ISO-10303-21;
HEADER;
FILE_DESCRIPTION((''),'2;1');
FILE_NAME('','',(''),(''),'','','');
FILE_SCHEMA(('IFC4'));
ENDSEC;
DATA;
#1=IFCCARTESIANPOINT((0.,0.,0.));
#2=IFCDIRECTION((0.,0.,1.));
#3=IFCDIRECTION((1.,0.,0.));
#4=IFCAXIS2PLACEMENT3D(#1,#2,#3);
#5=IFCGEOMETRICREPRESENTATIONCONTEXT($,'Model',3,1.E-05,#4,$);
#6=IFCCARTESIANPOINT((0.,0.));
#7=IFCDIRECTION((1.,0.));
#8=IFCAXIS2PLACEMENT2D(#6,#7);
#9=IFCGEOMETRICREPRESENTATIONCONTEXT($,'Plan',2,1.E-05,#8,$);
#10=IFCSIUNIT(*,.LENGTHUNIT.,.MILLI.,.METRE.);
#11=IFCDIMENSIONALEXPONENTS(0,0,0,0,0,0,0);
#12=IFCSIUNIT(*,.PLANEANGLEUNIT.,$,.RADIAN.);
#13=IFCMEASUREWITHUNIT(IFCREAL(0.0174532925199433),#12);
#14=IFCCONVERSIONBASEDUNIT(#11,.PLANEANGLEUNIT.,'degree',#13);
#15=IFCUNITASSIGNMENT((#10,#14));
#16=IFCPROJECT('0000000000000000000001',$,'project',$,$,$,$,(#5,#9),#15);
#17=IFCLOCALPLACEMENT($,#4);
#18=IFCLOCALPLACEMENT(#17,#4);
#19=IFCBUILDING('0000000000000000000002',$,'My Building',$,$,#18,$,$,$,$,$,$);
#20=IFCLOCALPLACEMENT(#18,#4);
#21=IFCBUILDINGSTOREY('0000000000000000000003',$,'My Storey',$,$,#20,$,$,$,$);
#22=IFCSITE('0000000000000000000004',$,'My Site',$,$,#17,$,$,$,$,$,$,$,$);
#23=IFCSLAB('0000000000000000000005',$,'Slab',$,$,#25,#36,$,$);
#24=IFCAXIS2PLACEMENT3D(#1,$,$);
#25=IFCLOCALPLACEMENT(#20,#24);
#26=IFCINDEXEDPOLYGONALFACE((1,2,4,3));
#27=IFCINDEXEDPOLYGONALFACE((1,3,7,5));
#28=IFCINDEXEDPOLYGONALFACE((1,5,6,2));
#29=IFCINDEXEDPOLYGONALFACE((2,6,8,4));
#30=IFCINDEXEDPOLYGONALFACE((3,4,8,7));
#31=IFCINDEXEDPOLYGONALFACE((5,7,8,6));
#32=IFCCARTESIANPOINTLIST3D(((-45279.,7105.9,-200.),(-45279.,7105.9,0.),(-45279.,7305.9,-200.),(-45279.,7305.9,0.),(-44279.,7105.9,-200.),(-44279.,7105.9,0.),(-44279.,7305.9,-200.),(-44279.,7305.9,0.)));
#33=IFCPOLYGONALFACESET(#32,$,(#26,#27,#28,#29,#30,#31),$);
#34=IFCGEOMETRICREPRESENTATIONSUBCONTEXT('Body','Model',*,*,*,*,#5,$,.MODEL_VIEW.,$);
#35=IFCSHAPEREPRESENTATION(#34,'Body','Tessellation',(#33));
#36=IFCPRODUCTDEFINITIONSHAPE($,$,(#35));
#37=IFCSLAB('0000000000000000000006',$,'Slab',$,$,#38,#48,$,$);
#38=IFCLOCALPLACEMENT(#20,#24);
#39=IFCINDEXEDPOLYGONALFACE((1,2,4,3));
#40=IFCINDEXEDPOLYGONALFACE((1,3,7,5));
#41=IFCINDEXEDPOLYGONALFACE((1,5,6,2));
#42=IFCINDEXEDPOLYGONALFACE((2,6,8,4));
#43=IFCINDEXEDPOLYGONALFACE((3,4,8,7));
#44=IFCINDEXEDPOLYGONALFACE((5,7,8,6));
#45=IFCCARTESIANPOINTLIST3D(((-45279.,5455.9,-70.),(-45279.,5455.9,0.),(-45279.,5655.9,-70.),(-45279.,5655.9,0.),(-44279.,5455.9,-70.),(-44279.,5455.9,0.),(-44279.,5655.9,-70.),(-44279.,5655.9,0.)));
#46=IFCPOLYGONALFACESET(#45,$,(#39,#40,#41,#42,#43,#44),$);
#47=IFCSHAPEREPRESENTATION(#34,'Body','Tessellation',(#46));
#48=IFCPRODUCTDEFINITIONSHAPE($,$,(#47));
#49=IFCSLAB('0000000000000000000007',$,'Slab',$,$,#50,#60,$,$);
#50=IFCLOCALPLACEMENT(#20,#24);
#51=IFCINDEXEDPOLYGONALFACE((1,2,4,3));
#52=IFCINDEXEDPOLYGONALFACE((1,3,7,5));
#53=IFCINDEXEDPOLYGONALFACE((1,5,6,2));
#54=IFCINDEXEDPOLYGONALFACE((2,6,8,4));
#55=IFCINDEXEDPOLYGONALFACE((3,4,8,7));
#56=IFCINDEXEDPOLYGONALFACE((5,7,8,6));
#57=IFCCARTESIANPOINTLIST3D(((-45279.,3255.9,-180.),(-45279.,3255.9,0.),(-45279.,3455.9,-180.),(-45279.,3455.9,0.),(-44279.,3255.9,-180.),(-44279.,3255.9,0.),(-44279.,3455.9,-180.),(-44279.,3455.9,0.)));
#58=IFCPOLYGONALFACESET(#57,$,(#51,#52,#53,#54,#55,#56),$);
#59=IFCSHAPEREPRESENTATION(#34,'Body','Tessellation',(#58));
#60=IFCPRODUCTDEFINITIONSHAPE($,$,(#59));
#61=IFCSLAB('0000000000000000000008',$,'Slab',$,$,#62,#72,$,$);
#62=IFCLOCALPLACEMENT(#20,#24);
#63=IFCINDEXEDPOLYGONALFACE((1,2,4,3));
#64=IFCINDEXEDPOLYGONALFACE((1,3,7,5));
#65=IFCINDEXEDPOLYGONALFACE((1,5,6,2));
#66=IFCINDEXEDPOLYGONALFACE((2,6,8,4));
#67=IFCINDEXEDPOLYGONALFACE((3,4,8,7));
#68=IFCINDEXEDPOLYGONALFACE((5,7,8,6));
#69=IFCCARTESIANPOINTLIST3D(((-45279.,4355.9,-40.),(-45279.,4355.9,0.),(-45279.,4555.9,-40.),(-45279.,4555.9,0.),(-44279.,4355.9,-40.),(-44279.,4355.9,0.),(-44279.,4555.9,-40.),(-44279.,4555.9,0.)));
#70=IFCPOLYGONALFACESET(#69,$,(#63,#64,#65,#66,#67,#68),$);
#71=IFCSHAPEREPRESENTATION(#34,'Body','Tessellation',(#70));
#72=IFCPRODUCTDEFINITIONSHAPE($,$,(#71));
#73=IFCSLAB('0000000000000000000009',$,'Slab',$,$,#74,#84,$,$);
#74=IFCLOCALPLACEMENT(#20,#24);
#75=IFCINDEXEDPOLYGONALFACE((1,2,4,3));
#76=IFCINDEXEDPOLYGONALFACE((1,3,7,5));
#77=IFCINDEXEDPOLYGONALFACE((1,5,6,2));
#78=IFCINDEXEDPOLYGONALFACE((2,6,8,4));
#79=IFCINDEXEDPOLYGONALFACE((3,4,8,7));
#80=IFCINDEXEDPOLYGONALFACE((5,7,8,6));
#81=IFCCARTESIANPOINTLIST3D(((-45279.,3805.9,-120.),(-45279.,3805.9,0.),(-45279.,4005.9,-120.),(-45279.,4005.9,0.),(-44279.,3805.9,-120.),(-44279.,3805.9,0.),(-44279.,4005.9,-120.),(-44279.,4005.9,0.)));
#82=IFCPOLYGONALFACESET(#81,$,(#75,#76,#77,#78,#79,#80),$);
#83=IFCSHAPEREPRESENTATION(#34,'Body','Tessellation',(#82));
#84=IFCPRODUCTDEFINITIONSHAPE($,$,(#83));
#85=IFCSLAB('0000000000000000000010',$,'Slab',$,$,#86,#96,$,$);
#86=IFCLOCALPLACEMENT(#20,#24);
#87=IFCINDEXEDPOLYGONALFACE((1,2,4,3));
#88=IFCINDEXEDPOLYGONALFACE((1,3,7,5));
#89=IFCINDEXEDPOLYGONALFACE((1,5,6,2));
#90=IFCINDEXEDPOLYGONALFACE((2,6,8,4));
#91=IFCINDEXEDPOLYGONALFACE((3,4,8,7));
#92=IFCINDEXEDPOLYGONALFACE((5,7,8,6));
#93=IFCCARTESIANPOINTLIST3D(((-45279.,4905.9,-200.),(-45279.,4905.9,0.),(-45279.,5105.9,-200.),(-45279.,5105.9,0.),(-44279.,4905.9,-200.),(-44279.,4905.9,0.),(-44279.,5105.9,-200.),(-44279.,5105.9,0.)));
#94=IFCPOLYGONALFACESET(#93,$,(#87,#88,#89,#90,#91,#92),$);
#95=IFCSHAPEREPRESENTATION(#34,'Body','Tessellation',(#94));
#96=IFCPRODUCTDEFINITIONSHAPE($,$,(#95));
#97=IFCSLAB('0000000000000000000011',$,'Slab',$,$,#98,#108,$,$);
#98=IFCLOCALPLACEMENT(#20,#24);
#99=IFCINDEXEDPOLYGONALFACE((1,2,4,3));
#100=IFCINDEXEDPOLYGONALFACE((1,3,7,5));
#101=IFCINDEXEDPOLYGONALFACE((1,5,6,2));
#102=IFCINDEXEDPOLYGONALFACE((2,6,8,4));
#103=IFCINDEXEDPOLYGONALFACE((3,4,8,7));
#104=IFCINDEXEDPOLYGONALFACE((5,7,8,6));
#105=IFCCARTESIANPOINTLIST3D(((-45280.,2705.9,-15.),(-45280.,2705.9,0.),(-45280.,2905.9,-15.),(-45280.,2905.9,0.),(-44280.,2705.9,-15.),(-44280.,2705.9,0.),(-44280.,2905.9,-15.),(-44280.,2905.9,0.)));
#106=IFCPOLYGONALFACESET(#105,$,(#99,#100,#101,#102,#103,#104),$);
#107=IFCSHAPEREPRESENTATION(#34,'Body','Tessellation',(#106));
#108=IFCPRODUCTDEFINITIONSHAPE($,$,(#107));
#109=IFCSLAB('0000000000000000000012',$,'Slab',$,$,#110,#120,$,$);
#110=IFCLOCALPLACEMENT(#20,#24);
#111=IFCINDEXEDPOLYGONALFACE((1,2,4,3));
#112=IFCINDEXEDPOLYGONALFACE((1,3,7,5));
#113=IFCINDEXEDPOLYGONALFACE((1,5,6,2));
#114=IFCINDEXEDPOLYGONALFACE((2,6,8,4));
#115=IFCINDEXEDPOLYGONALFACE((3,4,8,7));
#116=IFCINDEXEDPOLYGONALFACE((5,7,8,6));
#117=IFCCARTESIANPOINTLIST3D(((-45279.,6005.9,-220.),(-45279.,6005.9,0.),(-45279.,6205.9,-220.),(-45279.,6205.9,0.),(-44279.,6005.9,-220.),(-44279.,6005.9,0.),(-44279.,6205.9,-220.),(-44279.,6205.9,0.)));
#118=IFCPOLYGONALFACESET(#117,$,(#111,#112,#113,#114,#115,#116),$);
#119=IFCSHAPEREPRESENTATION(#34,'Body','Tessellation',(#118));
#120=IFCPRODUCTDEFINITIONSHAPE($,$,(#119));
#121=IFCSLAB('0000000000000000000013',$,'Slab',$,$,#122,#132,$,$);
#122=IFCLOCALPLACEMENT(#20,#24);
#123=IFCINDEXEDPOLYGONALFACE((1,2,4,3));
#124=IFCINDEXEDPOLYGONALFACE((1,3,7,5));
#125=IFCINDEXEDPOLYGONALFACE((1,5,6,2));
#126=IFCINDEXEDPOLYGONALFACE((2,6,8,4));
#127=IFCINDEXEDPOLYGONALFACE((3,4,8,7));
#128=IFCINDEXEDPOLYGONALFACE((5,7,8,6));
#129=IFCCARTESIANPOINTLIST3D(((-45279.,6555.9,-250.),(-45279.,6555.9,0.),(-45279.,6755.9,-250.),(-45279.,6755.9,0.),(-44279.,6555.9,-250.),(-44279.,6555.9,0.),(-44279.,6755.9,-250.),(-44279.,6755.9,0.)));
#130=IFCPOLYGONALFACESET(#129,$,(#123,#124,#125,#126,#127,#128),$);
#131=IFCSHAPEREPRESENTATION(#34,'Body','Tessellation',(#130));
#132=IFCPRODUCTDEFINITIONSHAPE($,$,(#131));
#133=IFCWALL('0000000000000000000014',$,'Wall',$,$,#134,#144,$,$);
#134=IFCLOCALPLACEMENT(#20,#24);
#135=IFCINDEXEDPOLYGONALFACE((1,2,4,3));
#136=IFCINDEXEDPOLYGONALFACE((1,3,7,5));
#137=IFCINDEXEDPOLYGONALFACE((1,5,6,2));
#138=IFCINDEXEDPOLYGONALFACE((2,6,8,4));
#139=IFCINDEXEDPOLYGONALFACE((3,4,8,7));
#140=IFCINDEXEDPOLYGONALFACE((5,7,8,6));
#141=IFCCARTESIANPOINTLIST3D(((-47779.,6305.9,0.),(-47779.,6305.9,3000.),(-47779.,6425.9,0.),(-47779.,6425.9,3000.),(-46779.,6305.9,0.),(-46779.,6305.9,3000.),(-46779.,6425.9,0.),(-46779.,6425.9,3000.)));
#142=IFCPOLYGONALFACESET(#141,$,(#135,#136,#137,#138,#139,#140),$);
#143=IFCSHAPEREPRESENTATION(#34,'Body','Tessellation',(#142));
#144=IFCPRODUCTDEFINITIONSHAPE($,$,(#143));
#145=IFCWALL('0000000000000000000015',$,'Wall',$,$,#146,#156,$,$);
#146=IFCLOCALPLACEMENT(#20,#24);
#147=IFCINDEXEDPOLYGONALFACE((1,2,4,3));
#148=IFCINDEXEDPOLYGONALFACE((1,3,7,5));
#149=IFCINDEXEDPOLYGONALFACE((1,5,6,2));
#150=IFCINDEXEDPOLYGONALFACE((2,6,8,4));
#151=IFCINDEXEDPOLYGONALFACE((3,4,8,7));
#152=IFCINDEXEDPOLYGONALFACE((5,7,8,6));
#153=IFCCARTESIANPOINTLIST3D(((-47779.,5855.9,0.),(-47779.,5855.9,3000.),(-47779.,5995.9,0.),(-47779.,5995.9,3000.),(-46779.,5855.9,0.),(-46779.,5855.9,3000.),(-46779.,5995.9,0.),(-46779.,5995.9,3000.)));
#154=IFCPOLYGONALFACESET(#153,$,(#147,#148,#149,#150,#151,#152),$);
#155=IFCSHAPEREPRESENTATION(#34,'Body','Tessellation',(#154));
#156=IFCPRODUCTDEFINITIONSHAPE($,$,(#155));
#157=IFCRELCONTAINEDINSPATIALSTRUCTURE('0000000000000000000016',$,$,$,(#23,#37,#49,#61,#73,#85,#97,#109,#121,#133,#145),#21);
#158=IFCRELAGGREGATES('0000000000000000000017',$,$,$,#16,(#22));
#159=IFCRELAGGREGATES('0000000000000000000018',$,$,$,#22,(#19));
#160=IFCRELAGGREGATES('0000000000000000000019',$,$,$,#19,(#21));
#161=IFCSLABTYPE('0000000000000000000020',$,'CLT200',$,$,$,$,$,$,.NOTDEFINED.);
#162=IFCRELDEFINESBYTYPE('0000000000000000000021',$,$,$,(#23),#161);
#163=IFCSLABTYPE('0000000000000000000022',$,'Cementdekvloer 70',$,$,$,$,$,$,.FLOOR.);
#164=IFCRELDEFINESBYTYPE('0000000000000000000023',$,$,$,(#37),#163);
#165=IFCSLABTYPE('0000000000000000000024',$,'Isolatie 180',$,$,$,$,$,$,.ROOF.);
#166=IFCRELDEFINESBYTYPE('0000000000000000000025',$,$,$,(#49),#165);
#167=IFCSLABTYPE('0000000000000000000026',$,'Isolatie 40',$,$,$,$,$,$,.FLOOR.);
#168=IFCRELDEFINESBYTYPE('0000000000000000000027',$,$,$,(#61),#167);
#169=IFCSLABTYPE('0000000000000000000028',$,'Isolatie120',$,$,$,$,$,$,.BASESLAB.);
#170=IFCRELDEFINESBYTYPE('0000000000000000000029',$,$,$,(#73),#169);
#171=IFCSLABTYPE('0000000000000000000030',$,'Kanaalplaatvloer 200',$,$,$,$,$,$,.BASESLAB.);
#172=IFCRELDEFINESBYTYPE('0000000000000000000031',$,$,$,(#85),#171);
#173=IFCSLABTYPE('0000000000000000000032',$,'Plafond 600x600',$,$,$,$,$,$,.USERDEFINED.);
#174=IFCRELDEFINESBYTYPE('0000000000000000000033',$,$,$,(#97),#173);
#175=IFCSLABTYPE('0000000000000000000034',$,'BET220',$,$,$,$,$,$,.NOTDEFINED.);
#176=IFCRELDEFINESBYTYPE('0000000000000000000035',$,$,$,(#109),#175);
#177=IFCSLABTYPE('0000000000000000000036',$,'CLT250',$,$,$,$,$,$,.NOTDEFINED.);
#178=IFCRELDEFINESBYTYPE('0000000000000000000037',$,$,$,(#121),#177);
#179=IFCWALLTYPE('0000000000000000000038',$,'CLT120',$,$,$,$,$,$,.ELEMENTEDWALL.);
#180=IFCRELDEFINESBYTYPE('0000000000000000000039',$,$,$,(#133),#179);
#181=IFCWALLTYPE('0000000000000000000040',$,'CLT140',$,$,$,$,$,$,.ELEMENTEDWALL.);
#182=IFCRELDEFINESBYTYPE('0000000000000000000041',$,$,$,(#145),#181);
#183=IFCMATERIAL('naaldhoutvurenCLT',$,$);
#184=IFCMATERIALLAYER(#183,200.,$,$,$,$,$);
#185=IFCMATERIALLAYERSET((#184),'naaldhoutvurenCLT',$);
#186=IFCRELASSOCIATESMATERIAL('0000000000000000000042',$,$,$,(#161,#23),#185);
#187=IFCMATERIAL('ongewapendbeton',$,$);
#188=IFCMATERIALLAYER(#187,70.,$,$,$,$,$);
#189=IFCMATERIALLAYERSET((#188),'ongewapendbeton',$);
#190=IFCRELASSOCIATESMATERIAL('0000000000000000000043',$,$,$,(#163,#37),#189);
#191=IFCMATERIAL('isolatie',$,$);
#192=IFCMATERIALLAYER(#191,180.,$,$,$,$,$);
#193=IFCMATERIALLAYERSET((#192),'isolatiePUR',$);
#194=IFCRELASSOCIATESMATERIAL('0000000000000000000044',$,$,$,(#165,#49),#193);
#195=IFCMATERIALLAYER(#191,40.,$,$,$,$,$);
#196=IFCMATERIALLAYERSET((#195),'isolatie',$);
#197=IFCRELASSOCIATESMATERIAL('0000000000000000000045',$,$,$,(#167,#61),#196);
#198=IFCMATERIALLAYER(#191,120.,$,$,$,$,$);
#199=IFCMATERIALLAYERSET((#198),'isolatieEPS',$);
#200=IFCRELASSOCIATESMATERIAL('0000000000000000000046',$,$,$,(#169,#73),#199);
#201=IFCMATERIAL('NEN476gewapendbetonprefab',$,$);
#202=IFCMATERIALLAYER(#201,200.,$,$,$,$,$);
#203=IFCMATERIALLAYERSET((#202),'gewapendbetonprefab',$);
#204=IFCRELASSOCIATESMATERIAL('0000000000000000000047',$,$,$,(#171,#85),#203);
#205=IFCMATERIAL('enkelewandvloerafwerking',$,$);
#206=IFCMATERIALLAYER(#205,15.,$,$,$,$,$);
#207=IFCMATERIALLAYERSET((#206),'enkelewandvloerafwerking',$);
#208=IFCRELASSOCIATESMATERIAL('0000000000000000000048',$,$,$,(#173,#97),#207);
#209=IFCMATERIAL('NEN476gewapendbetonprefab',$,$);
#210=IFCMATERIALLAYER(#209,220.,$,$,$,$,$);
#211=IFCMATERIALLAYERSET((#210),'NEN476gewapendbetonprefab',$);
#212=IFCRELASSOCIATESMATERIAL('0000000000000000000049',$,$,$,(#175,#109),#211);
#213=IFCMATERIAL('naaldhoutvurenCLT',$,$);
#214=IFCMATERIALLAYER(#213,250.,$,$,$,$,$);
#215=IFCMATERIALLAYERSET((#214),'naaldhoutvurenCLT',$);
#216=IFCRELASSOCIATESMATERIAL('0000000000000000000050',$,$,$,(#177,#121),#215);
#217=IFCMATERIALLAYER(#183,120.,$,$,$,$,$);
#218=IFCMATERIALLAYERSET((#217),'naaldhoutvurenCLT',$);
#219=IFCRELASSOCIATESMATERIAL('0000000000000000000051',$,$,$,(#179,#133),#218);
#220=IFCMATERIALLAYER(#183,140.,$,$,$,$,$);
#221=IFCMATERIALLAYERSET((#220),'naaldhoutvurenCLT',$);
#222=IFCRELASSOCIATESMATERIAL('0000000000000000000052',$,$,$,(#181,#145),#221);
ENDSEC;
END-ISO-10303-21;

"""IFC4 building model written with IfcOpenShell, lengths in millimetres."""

from ifc_helpers import new_model, entity, si_unit, converted_unit, frame, origin_with_axes, origin_2d_with_axis, place, context, subcontext, project, spatial, line, indexed_curve, outline, extrude, material, layer, layer_set, layer_usage, type_object, element, save


model = new_model("IFC4")

# Units and contexts
model_context = context("Model", 3, precision=1e-05, world=origin_with_axes())
plan_context = context("Plan", 2, precision=1e-05, world=origin_2d_with_axis())
body_context = subcontext(model_context, "Body", "Model", "MODEL_VIEW")
ifc_project = project(units=[si_unit("LENGTHUNIT", "METRE", prefix="MILLI"), converted_unit("PLANEANGLEUNIT", "degree", entity("IfcReal", 0.0174532925199433), si_unit("PLANEANGLEUNIT", "RADIAN"), dimensions=[0, 0, 0, 0, 0, 0, 0])], contexts=[model_context, plan_context])

# Site, building, storey
site_placement = place(None, origin_with_axes())
site = spatial("IfcSite", under=ifc_project, at=site_placement, Name="My Site")
building_placement = place(site_placement, origin_with_axes())
building = spatial("IfcBuilding", under=site, at=building_placement, Name="My Building")
storey_placement = place(building_placement, origin_with_axes())
storey = spatial("IfcBuildingStorey", under=building, at=storey_placement, Name="My Storey")

# Shared definitions
ifc_material_1 = material(Name="naaldhoutvurenCLT")

# Shared definitions
ifc_material_2 = material(Name="NEN476gewapendbetonprefab")

# Slabs
ifc_layer_1 = layer(ifc_material_1, 200.0)
ifc_layer_set_1 = layer_set([ifc_layer_1], Name="naaldhoutvurenCLT")
ifc_layer_usage_1 = layer_usage(ifc_layer_set_1, "AXIS3", "POSITIVE", 0.0)
slab_type_1 = type_object("IfcSlabType", Name="CLT200", PredefinedType="NOTDEFINED", material=ifc_layer_set_1)
slab_1_placement = place(storey_placement, frame((-45279.0, 7105.9, -200.0), z_axis=(0.0, 0.0, 1.0), x_axis=(1.0, 0.0, 0.0)))
element("IfcSlab", 1, at=slab_1_placement, inside=storey, type_object=slab_type_1, material=ifc_layer_usage_1, Name="Slab", context=body_context, shape_type="SweptSolid", body=[
    extrude(outline(indexed_curve([(1000.0, 200.0), (1000.0, 0.0), (0.0, 0.0), (0.0, 200.0)], segments=[line(3, 2), line(2, 1), line(1, 4), line(4, 3)], self_intersect=False)), None, (0.0, 0.0, 1.0), 200.0),
])
ifc_material_3 = material(Name="ongewapendbeton")
ifc_layer_2 = layer(ifc_material_3, 70.0)
ifc_layer_set_2 = layer_set([ifc_layer_2], Name="ongewapendbeton")
ifc_layer_usage_2 = layer_usage(ifc_layer_set_2, "AXIS3", "POSITIVE", 0.0)
slab_type_2 = type_object("IfcSlabType", Name="Cementdekvloer 70", PredefinedType="FLOOR", material=ifc_layer_set_2)
slab_2_placement = place(storey_placement, frame((-45279.0, 5455.9, -70.0), z_axis=(0.0, 0.0, 1.0), x_axis=(1.0, 0.0, 0.0)))
element("IfcSlab", 2, at=slab_2_placement, inside=storey, type_object=slab_type_2, material=ifc_layer_usage_2, Name="Slab", context=body_context, shape_type="SweptSolid", body=[
    extrude(outline(indexed_curve([(1000.0, 200.0), (1000.0, 0.0), (0.0, 0.0), (0.0, 200.0)], segments=[line(4, 1), line(1, 2), line(2, 3), line(3, 4)], self_intersect=False)), None, (0.0, 0.0, 1.0), 70.0),
])
ifc_material_4 = material(Name="isolatie")
ifc_layer_3 = layer(ifc_material_4, 180.0)
ifc_layer_set_3 = layer_set([ifc_layer_3], Name="isolatiePUR")
ifc_layer_usage_3 = layer_usage(ifc_layer_set_3, "AXIS3", "POSITIVE", 0.0)
slab_type_3 = type_object("IfcSlabType", Name="Isolatie 180", PredefinedType="ROOF", material=ifc_layer_set_3)
slab_3_placement = place(storey_placement, frame((-45279.0, 3255.9, -180.0), z_axis=(0.0, 0.0, 1.0), x_axis=(1.0, 0.0, 0.0)))
element("IfcSlab", 3, at=slab_3_placement, inside=storey, type_object=slab_type_3, material=ifc_layer_usage_3, Name="Slab", context=body_context, shape_type="SweptSolid", body=[
    extrude(outline(indexed_curve([(1000.0, 200.0), (1000.0, 0.0), (0.0, 0.0), (0.0, 200.0)], segments=[line(4, 1), line(1, 2), line(2, 3), line(3, 4)], self_intersect=False)), None, (0.0, 0.0, 1.0), 180.0),
])
ifc_layer_4 = layer(ifc_material_4, 40.0)
ifc_layer_set_4 = layer_set([ifc_layer_4], Name="isolatie")
ifc_layer_usage_4 = layer_usage(ifc_layer_set_4, "AXIS3", "POSITIVE", 0.0)
slab_type_4 = type_object("IfcSlabType", Name="Isolatie 40", PredefinedType="FLOOR", material=ifc_layer_set_4)
slab_4_placement = place(storey_placement, frame((-45279.0, 4355.9, -40.0), z_axis=(0.0, 0.0, 1.0), x_axis=(1.0, 0.0, 0.0)))
element("IfcSlab", 4, at=slab_4_placement, inside=storey, type_object=slab_type_4, material=ifc_layer_usage_4, Name="Slab", context=body_context, shape_type="SweptSolid", body=[
    extrude(outline(indexed_curve([(1000.0, 200.0), (1000.0, 0.0), (0.0, 0.0), (0.0, 200.0)], segments=[line(3, 2), line(2, 1), line(1, 4), line(4, 3)], self_intersect=False)), None, (0.0, 0.0, 1.0), 40.0),
])
ifc_layer_5 = layer(ifc_material_4, 120.0)
ifc_layer_set_5 = layer_set([ifc_layer_5], Name="isolatieEPS")
ifc_layer_usage_5 = layer_usage(ifc_layer_set_5, "AXIS3", "POSITIVE", 0.0)
slab_type_5 = type_object("IfcSlabType", Name="Isolatie120", PredefinedType="BASESLAB", material=ifc_layer_set_5)
slab_5_placement = place(storey_placement, frame((-45279.0, 3805.9, -120.0), z_axis=(0.0, 0.0, 1.0), x_axis=(1.0, 0.0, 0.0)))
element("IfcSlab", 5, at=slab_5_placement, inside=storey, type_object=slab_type_5, material=ifc_layer_usage_5, Name="Slab", context=body_context, shape_type="SweptSolid", body=[
    extrude(outline(indexed_curve([(1000.0, 200.0), (1000.0, 0.0), (0.0, 0.0), (0.0, 200.0)], segments=[line(3, 2), line(2, 1), line(1, 4), line(4, 3)], self_intersect=False)), None, (0.0, 0.0, 1.0), 120.0),
])
ifc_layer_6 = layer(ifc_material_2, 200.0)
ifc_layer_set_6 = layer_set([ifc_layer_6], Name="gewapendbetonprefab")
ifc_layer_usage_6 = layer_usage(ifc_layer_set_6, "AXIS3", "POSITIVE", 0.0)
slab_type_6 = type_object("IfcSlabType", Name="Kanaalplaatvloer 200", PredefinedType="BASESLAB", material=ifc_layer_set_6)
slab_6_placement = place(storey_placement, frame((-45279.0, 4905.9, -200.0), z_axis=(0.0, 0.0, 1.0), x_axis=(1.0, 0.0, 0.0)))
element("IfcSlab", 6, at=slab_6_placement, inside=storey, type_object=slab_type_6, material=ifc_layer_usage_6, Name="Slab", context=body_context, shape_type="SweptSolid", body=[
    extrude(outline(indexed_curve([(1000.0, 200.0), (1000.0, 0.0), (0.0, 0.0), (0.0, 200.0)], segments=[line(4, 1), line(1, 2), line(2, 3), line(3, 4)], self_intersect=False)), None, (0.0, 0.0, 1.0), 200.0),
])
ifc_material_5 = material(Name="enkelewandvloerafwerking")
ifc_layer_7 = layer(ifc_material_5, 15.0)
ifc_layer_set_7 = layer_set([ifc_layer_7], Name="enkelewandvloerafwerking")
ifc_layer_usage_7 = layer_usage(ifc_layer_set_7, "AXIS3", "POSITIVE", 0.0)
slab_type_7 = type_object("IfcSlabType", Name="Plafond 600x600", PredefinedType="USERDEFINED", material=ifc_layer_set_7)
slab_7_placement = place(storey_placement, frame((-45280.0, 2705.9, -15.0), z_axis=(0.0, 0.0, 1.0), x_axis=(1.0, 0.0, 0.0)))
element("IfcSlab", 7, at=slab_7_placement, inside=storey, type_object=slab_type_7, material=ifc_layer_usage_7, Name="Slab", context=body_context, shape_type="SweptSolid", body=[
    extrude(outline(indexed_curve([(1000.0, 200.0), (1000.0, 0.0), (0.0, 0.0), (0.0, 200.0)], segments=[line(4, 1), line(1, 2), line(2, 3), line(3, 4)], self_intersect=False)), None, (0.0, 0.0, 1.0), 15.0),
])
ifc_material_6 = material(Name="NEN476gewapendbetonprefab")
ifc_layer_8 = layer(ifc_material_6, 220.0)
ifc_layer_set_8 = layer_set([ifc_layer_8], Name="NEN476gewapendbetonprefab")
ifc_layer_usage_8 = layer_usage(ifc_layer_set_8, "AXIS3", "POSITIVE", 0.0)
slab_type_8 = type_object("IfcSlabType", Name="BET220", PredefinedType="NOTDEFINED", material=ifc_layer_set_8)
slab_8_placement = place(storey_placement, frame((-45279.0, 6005.9, -220.0), z_axis=(0.0, 0.0, 1.0), x_axis=(1.0, 0.0, 0.0)))
element("IfcSlab", 8, at=slab_8_placement, inside=storey, type_object=slab_type_8, material=ifc_layer_usage_8, Name="Slab", context=body_context, shape_type="SweptSolid", body=[
    extrude(outline(indexed_curve([(1000.0, 200.0), (1000.0, 0.0), (0.0, 0.0), (0.0, 200.0)], segments=[line(4, 1), line(1, 2), line(2, 3), line(3, 4)], self_intersect=False)), None, (0.0, 0.0, 1.0), 220.0),
])
ifc_material_7 = material(Name="naaldhoutvurenCLT")
ifc_layer_9 = layer(ifc_material_7, 250.0)
ifc_layer_set_9 = layer_set([ifc_layer_9], Name="naaldhoutvurenCLT")
ifc_layer_usage_9 = layer_usage(ifc_layer_set_9, "AXIS3", "POSITIVE", 0.0)
slab_type_9 = type_object("IfcSlabType", Name="CLT250", PredefinedType="NOTDEFINED", material=ifc_layer_set_9)
slab_9_placement = place(storey_placement, frame((-45279.0, 6555.9, -250.0), z_axis=(0.0, 0.0, 1.0), x_axis=(1.0, 0.0, 0.0)))
element("IfcSlab", 9, at=slab_9_placement, inside=storey, type_object=slab_type_9, material=ifc_layer_usage_9, Name="Slab", context=body_context, shape_type="SweptSolid", body=[
    extrude(outline(indexed_curve([(1000.0, 200.0), (1000.0, 0.0), (0.0, 0.0), (0.0, 200.0)], segments=[line(3, 2), line(2, 1), line(1, 4), line(4, 3)], self_intersect=False)), None, (0.0, 0.0, 1.0), 250.0),
])

# Walls
ifc_layer_10 = layer(ifc_material_1, 120.0)
ifc_layer_set_10 = layer_set([ifc_layer_10], Name="naaldhoutvurenCLT")
ifc_layer_usage_10 = layer_usage(ifc_layer_set_10, "AXIS2", "POSITIVE", 0.0)
wall_type_1 = type_object("IfcWallType", Name="CLT120", PredefinedType="ELEMENTEDWALL", material=ifc_layer_set_10)
wall_1_placement = place(storey_placement, frame((-47779.0, 6305.9, 0.0), z_axis=(0.0, 0.0, 1.0), x_axis=(1.0, 0.0, 0.0)))
element("IfcWall", 10, at=wall_1_placement, inside=storey, type_object=wall_type_1, material=ifc_layer_usage_10, Name="Wall", context=body_context, shape_type="SweptSolid", body=[
    extrude(outline(indexed_curve([(0.0, 0.0), (0.0, 120.0), (1000.0, 120.0), (1000.0, 0.0), (0.0, 0.0)], self_intersect=False)), origin_with_axes(), (0.0, 0.0, 1.0), 3000.0),
])
ifc_layer_11 = layer(ifc_material_1, 140.0)
ifc_layer_set_11 = layer_set([ifc_layer_11], Name="naaldhoutvurenCLT")
ifc_layer_usage_11 = layer_usage(ifc_layer_set_11, "AXIS2", "POSITIVE", 0.0)
wall_type_2 = type_object("IfcWallType", Name="CLT140", PredefinedType="ELEMENTEDWALL", material=ifc_layer_set_11)
wall_2_placement = place(storey_placement, frame((-47779.0, 5855.9, 0.0), z_axis=(0.0, 0.0, 1.0), x_axis=(1.0, 0.0, 0.0)))
element("IfcWall", 11, at=wall_2_placement, inside=storey, type_object=wall_type_2, material=ifc_layer_usage_11, Name="Wall", context=body_context, shape_type="SweptSolid", body=[
    extrude(outline(indexed_curve([(0.0, 0.0), (0.0, 140.0), (1000.0, 140.0), (1000.0, 0.0), (0.0, 0.0)], self_intersect=False)), origin_with_axes(), (0.0, 0.0, 1.0), 3000.0),
])

save(model, "model.ifc")
